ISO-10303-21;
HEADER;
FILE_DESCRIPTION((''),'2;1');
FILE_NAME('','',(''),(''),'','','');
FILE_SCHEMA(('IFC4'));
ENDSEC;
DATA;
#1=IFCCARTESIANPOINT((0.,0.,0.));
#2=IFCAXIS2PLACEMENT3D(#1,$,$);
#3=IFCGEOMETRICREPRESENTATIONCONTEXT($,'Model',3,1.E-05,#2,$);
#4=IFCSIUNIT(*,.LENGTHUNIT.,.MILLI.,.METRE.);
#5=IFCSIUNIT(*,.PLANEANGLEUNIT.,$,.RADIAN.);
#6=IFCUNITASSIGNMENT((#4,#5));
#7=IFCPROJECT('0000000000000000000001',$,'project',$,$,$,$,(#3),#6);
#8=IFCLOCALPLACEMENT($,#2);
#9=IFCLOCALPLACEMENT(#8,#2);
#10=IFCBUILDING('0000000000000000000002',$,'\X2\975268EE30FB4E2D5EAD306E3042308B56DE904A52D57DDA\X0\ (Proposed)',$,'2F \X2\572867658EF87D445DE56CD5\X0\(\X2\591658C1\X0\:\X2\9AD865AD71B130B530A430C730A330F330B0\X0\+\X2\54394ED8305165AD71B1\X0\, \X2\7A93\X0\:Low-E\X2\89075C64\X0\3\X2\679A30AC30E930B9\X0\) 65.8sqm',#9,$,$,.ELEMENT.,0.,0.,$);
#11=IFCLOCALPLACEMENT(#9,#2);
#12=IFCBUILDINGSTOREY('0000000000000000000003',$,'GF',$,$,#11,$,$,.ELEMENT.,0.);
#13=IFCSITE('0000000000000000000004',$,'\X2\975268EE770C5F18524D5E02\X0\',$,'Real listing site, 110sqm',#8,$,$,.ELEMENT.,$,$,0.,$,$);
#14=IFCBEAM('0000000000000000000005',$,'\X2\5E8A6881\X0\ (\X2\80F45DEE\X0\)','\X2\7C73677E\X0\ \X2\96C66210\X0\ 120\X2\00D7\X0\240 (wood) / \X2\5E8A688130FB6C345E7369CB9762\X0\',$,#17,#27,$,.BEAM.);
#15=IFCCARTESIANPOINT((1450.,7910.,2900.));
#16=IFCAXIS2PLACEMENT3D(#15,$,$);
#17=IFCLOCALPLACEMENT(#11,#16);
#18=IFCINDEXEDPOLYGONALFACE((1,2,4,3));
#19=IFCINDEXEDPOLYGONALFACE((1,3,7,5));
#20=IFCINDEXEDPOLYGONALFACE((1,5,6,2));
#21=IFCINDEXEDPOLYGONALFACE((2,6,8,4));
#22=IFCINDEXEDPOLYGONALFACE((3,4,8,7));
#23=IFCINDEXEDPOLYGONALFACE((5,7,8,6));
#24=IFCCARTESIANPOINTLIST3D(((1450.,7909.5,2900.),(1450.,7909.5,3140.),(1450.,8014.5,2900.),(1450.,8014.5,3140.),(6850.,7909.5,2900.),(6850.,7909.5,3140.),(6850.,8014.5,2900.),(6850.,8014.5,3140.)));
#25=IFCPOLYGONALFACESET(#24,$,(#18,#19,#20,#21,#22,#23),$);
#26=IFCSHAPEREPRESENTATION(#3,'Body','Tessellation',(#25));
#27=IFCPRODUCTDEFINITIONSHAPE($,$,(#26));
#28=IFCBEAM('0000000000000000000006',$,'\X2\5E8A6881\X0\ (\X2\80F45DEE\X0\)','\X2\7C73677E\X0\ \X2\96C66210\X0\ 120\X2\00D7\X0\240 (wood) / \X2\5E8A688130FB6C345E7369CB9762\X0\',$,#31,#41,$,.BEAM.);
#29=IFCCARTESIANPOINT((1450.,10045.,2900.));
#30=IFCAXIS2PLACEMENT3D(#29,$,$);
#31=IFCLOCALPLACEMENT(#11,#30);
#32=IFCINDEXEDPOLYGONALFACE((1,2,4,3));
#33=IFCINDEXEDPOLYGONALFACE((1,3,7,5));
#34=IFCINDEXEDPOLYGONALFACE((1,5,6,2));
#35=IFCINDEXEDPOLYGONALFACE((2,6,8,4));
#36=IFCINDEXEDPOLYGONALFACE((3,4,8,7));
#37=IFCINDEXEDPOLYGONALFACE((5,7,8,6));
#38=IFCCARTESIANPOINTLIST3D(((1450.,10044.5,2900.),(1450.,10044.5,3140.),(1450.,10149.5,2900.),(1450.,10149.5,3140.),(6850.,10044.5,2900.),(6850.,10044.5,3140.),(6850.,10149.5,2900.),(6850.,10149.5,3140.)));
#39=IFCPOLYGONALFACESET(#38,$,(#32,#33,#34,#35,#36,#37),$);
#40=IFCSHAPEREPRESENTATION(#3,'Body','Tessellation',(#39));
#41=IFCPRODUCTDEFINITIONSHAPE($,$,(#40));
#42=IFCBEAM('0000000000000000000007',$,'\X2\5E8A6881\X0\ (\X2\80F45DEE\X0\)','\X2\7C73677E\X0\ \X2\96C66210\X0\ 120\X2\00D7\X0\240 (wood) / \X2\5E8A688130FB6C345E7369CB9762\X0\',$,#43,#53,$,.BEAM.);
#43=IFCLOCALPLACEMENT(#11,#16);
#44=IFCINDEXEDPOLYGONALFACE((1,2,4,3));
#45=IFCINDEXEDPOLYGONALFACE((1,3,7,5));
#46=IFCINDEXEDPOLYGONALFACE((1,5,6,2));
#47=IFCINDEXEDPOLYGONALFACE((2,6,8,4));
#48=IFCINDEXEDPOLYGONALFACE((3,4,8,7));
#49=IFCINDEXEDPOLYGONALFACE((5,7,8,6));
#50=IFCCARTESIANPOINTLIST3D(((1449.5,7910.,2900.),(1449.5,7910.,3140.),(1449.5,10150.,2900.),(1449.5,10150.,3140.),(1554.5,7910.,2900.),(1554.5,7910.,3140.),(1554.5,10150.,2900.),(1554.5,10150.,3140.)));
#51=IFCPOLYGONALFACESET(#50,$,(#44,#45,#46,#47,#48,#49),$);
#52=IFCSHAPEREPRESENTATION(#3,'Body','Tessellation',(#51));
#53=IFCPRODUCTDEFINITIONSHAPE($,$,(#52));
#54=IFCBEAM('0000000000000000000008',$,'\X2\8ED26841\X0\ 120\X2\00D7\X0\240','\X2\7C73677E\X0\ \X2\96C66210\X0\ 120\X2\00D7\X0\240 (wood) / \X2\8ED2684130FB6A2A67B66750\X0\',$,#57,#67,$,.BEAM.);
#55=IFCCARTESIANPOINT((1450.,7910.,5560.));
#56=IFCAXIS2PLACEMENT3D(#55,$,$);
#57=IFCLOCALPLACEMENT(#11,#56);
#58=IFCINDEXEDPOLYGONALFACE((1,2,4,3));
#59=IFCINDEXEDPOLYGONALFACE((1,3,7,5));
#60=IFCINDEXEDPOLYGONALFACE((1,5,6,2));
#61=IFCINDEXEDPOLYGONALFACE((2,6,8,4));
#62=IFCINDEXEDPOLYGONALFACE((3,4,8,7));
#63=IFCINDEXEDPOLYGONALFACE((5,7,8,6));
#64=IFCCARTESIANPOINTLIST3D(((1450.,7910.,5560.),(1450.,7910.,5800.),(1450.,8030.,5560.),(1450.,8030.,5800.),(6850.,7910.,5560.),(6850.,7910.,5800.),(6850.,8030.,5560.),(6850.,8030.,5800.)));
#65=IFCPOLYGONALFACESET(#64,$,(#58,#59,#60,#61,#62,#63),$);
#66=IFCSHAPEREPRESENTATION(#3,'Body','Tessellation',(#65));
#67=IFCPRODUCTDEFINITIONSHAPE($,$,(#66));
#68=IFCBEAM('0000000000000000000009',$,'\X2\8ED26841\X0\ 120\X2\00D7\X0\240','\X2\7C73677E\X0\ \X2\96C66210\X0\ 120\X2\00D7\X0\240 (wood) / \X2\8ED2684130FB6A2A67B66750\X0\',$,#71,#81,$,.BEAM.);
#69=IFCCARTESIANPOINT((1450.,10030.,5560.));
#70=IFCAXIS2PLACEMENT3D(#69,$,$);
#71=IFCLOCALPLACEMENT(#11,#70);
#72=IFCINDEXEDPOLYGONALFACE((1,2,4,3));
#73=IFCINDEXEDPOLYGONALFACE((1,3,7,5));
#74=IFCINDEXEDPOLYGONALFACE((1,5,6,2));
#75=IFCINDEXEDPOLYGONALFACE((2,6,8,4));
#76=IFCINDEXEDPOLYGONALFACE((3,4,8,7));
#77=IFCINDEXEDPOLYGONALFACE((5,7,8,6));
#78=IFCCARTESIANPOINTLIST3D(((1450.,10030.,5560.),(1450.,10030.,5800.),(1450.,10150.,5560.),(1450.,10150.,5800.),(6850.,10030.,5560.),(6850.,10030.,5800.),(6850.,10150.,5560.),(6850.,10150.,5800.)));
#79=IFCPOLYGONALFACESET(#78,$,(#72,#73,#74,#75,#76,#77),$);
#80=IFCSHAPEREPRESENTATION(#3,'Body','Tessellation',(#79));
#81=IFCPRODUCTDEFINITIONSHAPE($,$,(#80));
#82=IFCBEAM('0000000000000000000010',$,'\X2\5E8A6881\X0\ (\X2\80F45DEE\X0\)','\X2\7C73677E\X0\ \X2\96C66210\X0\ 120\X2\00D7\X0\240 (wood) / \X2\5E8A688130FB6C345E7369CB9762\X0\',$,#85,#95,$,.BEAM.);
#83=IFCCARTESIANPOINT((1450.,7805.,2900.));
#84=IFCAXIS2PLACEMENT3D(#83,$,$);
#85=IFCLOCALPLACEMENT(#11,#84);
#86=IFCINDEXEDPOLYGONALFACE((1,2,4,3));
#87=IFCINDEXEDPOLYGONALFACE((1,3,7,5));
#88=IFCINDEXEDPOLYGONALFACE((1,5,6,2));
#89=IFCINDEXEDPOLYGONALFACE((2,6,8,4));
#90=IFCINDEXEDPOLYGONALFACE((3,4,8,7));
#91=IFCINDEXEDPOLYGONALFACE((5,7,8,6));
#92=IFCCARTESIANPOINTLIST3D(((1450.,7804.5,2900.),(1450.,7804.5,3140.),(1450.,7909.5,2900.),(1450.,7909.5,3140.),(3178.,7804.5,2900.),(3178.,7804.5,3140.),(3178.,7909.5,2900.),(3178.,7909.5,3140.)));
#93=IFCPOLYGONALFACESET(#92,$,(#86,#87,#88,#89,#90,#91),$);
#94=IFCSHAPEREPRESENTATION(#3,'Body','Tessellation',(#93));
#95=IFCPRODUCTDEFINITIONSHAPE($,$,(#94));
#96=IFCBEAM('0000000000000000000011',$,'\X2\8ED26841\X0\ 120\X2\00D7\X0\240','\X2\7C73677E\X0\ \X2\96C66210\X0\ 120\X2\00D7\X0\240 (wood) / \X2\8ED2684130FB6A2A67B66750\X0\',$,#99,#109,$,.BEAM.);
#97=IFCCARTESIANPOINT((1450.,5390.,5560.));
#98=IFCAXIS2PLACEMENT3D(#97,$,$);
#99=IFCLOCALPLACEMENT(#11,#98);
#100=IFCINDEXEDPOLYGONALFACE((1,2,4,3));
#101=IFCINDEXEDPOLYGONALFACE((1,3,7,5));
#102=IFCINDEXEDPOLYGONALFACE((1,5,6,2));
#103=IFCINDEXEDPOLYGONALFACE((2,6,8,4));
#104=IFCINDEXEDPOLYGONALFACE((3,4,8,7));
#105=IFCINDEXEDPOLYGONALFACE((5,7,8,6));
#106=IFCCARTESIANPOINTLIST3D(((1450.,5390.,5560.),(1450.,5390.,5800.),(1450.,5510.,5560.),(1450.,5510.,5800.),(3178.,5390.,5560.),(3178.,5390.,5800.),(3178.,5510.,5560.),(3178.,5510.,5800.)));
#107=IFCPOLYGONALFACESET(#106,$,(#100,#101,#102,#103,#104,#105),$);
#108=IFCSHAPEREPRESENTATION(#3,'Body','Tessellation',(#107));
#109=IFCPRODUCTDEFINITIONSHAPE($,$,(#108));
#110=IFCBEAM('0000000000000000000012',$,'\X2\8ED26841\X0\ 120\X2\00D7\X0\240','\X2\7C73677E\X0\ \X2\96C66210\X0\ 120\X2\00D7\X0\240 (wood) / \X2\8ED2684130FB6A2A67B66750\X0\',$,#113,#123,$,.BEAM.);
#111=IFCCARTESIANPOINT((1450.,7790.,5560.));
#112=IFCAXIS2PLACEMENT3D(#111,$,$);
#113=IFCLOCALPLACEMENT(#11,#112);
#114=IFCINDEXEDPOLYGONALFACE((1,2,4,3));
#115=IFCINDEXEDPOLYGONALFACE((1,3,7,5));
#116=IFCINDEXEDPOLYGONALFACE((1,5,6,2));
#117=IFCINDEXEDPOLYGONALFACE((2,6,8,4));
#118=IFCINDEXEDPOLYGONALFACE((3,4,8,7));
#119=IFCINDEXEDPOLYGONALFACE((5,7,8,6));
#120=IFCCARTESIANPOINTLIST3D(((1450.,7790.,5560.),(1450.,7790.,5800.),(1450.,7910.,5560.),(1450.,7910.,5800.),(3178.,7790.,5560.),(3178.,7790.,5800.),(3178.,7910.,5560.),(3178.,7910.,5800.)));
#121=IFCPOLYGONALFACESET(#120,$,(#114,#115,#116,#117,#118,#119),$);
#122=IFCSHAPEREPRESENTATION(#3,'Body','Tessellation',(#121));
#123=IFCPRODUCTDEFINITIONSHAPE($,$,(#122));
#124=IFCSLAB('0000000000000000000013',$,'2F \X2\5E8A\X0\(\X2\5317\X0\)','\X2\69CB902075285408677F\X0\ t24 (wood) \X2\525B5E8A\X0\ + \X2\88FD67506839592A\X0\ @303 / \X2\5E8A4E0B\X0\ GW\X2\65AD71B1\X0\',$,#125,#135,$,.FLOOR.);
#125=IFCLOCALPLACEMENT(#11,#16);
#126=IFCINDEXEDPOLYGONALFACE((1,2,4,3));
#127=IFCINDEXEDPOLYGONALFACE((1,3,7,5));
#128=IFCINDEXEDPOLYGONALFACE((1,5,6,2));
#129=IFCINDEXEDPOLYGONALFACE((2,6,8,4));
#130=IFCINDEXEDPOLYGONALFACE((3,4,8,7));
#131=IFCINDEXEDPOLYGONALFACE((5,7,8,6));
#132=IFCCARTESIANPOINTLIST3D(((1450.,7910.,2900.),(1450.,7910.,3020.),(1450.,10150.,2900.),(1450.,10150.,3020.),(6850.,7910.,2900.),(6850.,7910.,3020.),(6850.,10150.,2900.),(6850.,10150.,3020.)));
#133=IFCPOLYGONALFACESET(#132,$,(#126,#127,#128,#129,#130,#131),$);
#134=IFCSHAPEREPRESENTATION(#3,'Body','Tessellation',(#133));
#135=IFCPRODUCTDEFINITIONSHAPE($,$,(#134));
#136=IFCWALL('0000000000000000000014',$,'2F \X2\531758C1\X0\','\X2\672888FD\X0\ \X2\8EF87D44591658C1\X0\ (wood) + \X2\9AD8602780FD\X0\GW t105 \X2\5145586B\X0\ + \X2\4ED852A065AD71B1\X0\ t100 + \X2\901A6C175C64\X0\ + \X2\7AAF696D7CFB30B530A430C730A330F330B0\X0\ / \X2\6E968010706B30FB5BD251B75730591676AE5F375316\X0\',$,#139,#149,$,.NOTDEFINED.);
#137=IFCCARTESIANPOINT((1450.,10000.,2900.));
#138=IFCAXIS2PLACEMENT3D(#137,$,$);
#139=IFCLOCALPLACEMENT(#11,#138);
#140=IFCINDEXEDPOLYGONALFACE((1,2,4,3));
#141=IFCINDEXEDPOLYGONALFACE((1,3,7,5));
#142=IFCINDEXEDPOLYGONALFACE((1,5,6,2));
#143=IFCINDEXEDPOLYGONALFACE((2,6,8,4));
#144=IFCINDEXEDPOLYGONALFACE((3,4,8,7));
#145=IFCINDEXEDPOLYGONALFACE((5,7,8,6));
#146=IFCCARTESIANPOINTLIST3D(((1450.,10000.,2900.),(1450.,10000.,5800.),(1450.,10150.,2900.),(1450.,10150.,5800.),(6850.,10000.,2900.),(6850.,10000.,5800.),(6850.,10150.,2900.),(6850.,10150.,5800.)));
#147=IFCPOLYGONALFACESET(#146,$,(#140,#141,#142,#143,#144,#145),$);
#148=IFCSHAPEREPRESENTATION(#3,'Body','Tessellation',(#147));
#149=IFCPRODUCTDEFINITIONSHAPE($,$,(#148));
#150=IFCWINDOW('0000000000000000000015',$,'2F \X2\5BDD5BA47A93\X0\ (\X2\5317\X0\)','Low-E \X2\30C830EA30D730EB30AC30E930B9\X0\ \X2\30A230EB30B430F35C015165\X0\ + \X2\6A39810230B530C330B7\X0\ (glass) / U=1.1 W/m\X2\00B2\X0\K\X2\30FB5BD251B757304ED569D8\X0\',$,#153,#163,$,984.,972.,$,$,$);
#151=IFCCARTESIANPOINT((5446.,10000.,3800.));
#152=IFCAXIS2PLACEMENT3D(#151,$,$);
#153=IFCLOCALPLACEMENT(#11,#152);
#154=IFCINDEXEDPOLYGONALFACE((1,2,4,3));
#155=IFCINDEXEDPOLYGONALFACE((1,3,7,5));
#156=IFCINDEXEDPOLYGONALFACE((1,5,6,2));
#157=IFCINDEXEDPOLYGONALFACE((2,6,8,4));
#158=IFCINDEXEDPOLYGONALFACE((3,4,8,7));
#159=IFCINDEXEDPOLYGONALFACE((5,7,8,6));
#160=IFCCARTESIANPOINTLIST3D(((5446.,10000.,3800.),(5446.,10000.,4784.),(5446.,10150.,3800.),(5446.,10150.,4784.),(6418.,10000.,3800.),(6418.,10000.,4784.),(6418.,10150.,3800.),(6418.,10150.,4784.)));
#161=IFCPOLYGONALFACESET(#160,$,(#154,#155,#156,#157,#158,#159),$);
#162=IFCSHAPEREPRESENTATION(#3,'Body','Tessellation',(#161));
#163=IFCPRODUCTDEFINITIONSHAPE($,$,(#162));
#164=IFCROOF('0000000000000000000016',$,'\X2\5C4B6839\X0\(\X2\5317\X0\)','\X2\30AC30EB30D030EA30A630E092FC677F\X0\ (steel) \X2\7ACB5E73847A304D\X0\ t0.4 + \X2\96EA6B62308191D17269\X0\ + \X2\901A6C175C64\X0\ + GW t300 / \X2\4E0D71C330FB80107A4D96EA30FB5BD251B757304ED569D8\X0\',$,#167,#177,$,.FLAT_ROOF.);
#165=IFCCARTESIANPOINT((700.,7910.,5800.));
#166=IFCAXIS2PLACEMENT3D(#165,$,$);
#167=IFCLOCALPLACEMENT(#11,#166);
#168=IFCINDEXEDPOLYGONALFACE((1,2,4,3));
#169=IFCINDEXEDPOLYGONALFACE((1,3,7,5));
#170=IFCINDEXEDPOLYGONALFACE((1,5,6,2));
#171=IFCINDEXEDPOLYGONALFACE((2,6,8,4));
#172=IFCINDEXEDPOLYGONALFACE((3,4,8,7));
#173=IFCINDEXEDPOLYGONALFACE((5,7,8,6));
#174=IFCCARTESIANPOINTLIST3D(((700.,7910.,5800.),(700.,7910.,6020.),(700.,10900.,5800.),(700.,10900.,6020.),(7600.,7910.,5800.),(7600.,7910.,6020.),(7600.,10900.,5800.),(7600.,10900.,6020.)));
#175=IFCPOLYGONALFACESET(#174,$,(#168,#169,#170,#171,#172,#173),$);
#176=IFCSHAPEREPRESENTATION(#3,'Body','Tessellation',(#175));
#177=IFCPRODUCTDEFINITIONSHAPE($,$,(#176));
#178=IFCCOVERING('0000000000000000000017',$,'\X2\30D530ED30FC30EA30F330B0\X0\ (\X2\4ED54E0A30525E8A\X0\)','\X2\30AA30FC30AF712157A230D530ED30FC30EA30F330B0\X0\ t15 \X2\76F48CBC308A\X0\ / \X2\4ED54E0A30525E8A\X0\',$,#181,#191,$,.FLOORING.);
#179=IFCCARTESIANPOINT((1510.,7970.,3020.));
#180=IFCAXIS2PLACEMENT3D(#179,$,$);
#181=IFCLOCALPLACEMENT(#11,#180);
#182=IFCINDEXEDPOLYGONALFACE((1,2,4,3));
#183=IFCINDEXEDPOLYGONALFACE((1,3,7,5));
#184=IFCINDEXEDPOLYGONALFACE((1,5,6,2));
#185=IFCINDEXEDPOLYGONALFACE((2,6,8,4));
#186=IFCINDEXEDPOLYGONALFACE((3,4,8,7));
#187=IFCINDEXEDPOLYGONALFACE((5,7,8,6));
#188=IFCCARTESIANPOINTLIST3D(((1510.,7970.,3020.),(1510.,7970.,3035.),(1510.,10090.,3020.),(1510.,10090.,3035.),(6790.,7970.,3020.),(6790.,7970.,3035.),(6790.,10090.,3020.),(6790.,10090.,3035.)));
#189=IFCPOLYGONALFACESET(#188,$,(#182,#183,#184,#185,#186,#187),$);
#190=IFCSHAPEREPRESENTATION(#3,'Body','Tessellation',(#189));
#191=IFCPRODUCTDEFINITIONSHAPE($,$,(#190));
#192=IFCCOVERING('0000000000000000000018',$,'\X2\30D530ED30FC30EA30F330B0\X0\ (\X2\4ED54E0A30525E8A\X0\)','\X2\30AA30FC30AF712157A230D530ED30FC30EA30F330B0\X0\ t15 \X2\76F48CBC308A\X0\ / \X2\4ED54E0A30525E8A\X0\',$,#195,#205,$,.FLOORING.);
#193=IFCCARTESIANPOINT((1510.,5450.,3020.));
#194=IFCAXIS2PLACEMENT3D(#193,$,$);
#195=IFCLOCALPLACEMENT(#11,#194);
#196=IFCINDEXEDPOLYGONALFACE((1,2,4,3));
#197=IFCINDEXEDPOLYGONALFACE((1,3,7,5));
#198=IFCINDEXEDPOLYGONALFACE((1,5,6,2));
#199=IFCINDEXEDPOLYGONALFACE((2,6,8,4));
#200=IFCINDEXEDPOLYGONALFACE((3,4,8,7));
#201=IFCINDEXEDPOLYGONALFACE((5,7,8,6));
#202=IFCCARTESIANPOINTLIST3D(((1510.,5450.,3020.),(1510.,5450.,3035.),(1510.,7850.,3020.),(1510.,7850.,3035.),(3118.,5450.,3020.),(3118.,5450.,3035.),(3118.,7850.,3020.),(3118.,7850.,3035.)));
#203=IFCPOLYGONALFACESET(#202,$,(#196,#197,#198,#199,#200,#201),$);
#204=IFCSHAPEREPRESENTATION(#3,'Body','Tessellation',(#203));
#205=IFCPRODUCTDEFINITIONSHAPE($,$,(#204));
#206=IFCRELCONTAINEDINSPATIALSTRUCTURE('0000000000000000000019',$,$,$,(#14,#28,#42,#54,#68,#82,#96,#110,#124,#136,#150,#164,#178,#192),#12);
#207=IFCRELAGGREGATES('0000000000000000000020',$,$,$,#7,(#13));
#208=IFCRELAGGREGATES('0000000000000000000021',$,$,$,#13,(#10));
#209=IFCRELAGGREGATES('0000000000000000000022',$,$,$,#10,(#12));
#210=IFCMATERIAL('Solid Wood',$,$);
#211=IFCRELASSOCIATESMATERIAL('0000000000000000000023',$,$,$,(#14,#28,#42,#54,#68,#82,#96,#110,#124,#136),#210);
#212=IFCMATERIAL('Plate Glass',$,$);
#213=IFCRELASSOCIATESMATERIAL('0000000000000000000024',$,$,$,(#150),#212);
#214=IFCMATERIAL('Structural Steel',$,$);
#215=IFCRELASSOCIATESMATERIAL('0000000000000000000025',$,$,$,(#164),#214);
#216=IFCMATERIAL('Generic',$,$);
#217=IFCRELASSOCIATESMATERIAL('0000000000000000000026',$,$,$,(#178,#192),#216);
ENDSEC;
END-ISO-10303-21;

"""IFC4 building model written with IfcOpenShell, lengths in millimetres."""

from ifc_helpers import new_model, si_unit, frame, frame_2d, origin, place, context, project, spatial, rectangle, extrude, material, element, fill, save


model = new_model("IFC4")

# Units and contexts
model_context = context("Model", 3, precision=1e-05, world=origin())
ifc_project = project(units=[si_unit("LENGTHUNIT", "METRE", prefix="MILLI"), si_unit("PLANEANGLEUNIT", "RADIAN")], contexts=[model_context])

# Site, building, storey
site_placement = place(None, origin())
site = spatial("IfcSite", under=ifc_project, at=site_placement, Name="青森県弘前市", ObjectType="Real listing site, 110sqm", CompositionType="ELEMENT", RefElevation=0.0)
building_placement = place(site_placement, origin())
building = spatial("IfcBuilding", under=site, at=building_placement, Name="青森・中庭のある回遊動線 (Proposed)", ObjectType="2F 在来軸組工法(外壁:高断熱サイディング+吹付け断熱, 窓:Low-E複層3枚ガラス) 65.8sqm", CompositionType="ELEMENT", ElevationOfRefHeight=0.0, ElevationOfTerrain=0.0)
storey_placement = place(building_placement, origin())
storey = spatial("IfcBuildingStorey", under=building, at=storey_placement, Name="GF", CompositionType="ELEMENT", Elevation=0.0)

# Shared definitions
ifc_material_1 = material(Name="Solid Wood")

# Beams
beam_1_placement = place(storey_placement, frame((1450.0, 7910.0, 2900.0)))
element("IfcBeam", 1, at=beam_1_placement, inside=storey, material=ifc_material_1, Name="床梁 (胴差)", Description="米松 集成 120×240 (wood) / 床梁・水平構面", PredefinedType="BEAM", context=model_context, shape_type="SweptSolid", body=[
    extrude(rectangle(XDim=5400.0, YDim=105.0, at=frame_2d((2700.0, 52.0))), frame((1450.0, 7910.0, 2900.0)), (0.0, 0.0, 1.0), 240.0),
])
beam_2_placement = place(storey_placement, frame((1450.0, 10045.0, 2900.0)))
element("IfcBeam", 2, at=beam_2_placement, inside=storey, material=ifc_material_1, Name="床梁 (胴差)", Description="米松 集成 120×240 (wood) / 床梁・水平構面", PredefinedType="BEAM", context=model_context, shape_type="SweptSolid", body=[
    extrude(rectangle(XDim=5400.0, YDim=105.0, at=frame_2d((2700.0, 52.0))), frame((1450.0, 10045.0, 2900.0)), (0.0, 0.0, 1.0), 240.0),
])
beam_3_placement = place(storey_placement, frame((1450.0, 7910.0, 2900.0)))
element("IfcBeam", 3, at=beam_3_placement, inside=storey, material=ifc_material_1, Name="床梁 (胴差)", Description="米松 集成 120×240 (wood) / 床梁・水平構面", PredefinedType="BEAM", context=model_context, shape_type="SweptSolid", body=[
    extrude(rectangle(XDim=105.0, YDim=2240.0, at=frame_2d((52.0, 1120.0))), frame((1450.0, 7910.0, 2900.0)), (0.0, 0.0, 1.0), 240.0),
])
beam_4_placement = place(storey_placement, frame((1450.0, 7910.0, 5560.0)))
element("IfcBeam", 4, at=beam_4_placement, inside=storey, material=ifc_material_1, Name="軒桁 120×240", Description="米松 集成 120×240 (wood) / 軒桁・横架材", PredefinedType="BEAM", context=model_context, shape_type="SweptSolid", body=[
    extrude(rectangle(XDim=5400.0, YDim=120.0, at=frame_2d((2700.0, 60.0))), frame((1450.0, 7910.0, 5560.0)), (0.0, 0.0, 1.0), 240.0),
])
beam_5_placement = place(storey_placement, frame((1450.0, 10030.0, 5560.0)))
element("IfcBeam", 5, at=beam_5_placement, inside=storey, material=ifc_material_1, Name="軒桁 120×240", Description="米松 集成 120×240 (wood) / 軒桁・横架材", PredefinedType="BEAM", context=model_context, shape_type="SweptSolid", body=[
    extrude(rectangle(XDim=5400.0, YDim=120.0, at=frame_2d((2700.0, 60.0))), frame((1450.0, 10030.0, 5560.0)), (0.0, 0.0, 1.0), 240.0),
])
beam_6_placement = place(storey_placement, frame((1450.0, 7805.0, 2900.0)))
element("IfcBeam", 6, at=beam_6_placement, inside=storey, material=ifc_material_1, Name="床梁 (胴差)", Description="米松 集成 120×240 (wood) / 床梁・水平構面", PredefinedType="BEAM", context=model_context, shape_type="SweptSolid", body=[
    extrude(rectangle(XDim=1728.0, YDim=105.0, at=frame_2d((864.0, 52.0))), frame((1450.0, 7805.0, 2900.0)), (0.0, 0.0, 1.0), 240.0),
])
beam_7_placement = place(storey_placement, frame((1450.0, 5390.0, 5560.0)))
element("IfcBeam", 7, at=beam_7_placement, inside=storey, material=ifc_material_1, Name="軒桁 120×240", Description="米松 集成 120×240 (wood) / 軒桁・横架材", PredefinedType="BEAM", context=model_context, shape_type="SweptSolid", body=[
    extrude(rectangle(XDim=1728.0, YDim=120.0, at=frame_2d((864.0, 60.0))), frame((1450.0, 5390.0, 5560.0)), (0.0, 0.0, 1.0), 240.0),
])
beam_8_placement = place(storey_placement, frame((1450.0, 7790.0, 5560.0)))
element("IfcBeam", 8, at=beam_8_placement, inside=storey, material=ifc_material_1, Name="軒桁 120×240", Description="米松 集成 120×240 (wood) / 軒桁・横架材", PredefinedType="BEAM", context=model_context, shape_type="SweptSolid", body=[
    extrude(rectangle(XDim=1728.0, YDim=120.0, at=frame_2d((864.0, 60.0))), frame((1450.0, 7790.0, 5560.0)), (0.0, 0.0, 1.0), 240.0),
])

# Slab
slab_placement = place(storey_placement, frame((1450.0, 7910.0, 2900.0)))
element("IfcSlab", 9, at=slab_placement, inside=storey, material=ifc_material_1, Name="2F 床(北)", Description="構造用合板 t24 (wood) 剛床 + 製材根太 @303 / 床下 GW断熱", PredefinedType="FLOOR", context=model_context, shape_type="SweptSolid", body=[
    extrude(rectangle(XDim=5400.0, YDim=2240.0, at=frame_2d((2700.0, 1120.0))), frame((1450.0, 7910.0, 2900.0)), (0.0, 0.0, 1.0), 120.0),
])

# Wall, opening, window
wall_placement = place(storey_placement, frame((1450.0, 10000.0, 2900.0)))
wall = element("IfcWall", 10, at=wall_placement, inside=storey, material=ifc_material_1, Name="2F 北壁", Description="木製 軸組外壁 (wood) + 高性能GW t105 充填 + 付加断熱 t100 + 通気層 + 窯業系サイディング / 準耐火・寒冷地外皮強化", PredefinedType="NOTDEFINED", context=model_context, shape_type="SweptSolid", body=[
    extrude(rectangle(XDim=5400.0, YDim=150.0, at=frame_2d((2700.0, 75.0))), frame((1450.0, 10000.0, 2900.0)), (0.0, 0.0, 1.0), 2900.0),
])
opening_placement = place(storey_placement, frame((5446.0, 10000.0, 3800.0)))
opening = element("IfcOpeningElement", 11, at=opening_placement, cuts=wall, PredefinedType="NOTDEFINED", context=model_context, shape_type="SweptSolid", body=[
    extrude(rectangle(XDim=972.0, YDim=150.0, at=frame_2d((486.0, 75.0))), frame((5446.0, 10000.0, 3800.0)), (0.0, 0.0, 1.0), 984.0),
])
ifc_material_2 = material(Name="Plate Glass")
window_placement = place(storey_placement, frame((5446.0, 10000.0, 3800.0)))
window = element("IfcWindow", 12, at=window_placement, inside=storey, material=ifc_material_2, Name="2F 寝室窓 (北)", Description="Low-E トリプルガラス アルゴン封入 + 樹脂サッシ (glass) / U=1.1 W/m²K・寒冷地仕様", OverallHeight=984.0, OverallWidth=972.0, context=model_context, shape_type="SweptSolid", body=[
    extrude(rectangle(XDim=972.0, YDim=150.0, at=frame_2d((486.0, 75.0))), frame((5446.0, 10000.0, 3800.0)), (0.0, 0.0, 1.0), 984.0),
])
fill(opening, window)

# Roof
ifc_material_3 = material(Name="Structural Steel")
for number, where, name in (
    (13, (700.0, 7910.0, 5800.0), "屋根(北)"),
):
    element("IfcRoof", number, at=place(storey_placement, frame(where)), inside=storey, material=ifc_material_3, Name=name, Description="ガルバリウム鋼板 (steel) 立平葺き t0.4 + 雪止め金物 + 通気層 + GW t300 / 不燃・耐積雪・寒冷地仕様", PredefinedType="FLAT_ROOF", context=model_context, shape_type="SweptSolid", body=[
        extrude(rectangle(XDim=6900.0, YDim=2990.0, at=frame_2d((3450.0, 1495.0))), frame((700.0, 7910.0, 5800.0)), (0.0, 0.0, 1.0), 220.0),
    ])

# Coverings
ifc_material_4 = material(Name="Generic")
covering_1_placement = place(storey_placement, frame((1510.0, 7970.0, 3020.0)))
element("IfcCovering", 14, at=covering_1_placement, inside=storey, material=ifc_material_4, Name="フローリング (仕上げ床)", Description="オーク無垢フローリング t15 直貼り / 仕上げ床", PredefinedType="FLOORING", context=model_context, shape_type="SweptSolid", body=[
    extrude(rectangle(XDim=5280.0, YDim=2120.0, at=frame_2d((2640.0, 1060.0))), frame((1510.0, 7970.0, 3020.0)), (0.0, 0.0, 1.0), 15.0),
])
covering_2_placement = place(storey_placement, frame((1510.0, 5450.0, 3020.0)))
element("IfcCovering", 15, at=covering_2_placement, inside=storey, material=ifc_material_4, Name="フローリング (仕上げ床)", Description="オーク無垢フローリング t15 直貼り / 仕上げ床", PredefinedType="FLOORING", context=model_context, shape_type="SweptSolid", body=[
    extrude(rectangle(XDim=1608.0, YDim=2400.0, at=frame_2d((804.0, 1200.0))), frame((1510.0, 5450.0, 3020.0)), (0.0, 0.0, 1.0), 15.0),
])

save(model, "model.ifc")
